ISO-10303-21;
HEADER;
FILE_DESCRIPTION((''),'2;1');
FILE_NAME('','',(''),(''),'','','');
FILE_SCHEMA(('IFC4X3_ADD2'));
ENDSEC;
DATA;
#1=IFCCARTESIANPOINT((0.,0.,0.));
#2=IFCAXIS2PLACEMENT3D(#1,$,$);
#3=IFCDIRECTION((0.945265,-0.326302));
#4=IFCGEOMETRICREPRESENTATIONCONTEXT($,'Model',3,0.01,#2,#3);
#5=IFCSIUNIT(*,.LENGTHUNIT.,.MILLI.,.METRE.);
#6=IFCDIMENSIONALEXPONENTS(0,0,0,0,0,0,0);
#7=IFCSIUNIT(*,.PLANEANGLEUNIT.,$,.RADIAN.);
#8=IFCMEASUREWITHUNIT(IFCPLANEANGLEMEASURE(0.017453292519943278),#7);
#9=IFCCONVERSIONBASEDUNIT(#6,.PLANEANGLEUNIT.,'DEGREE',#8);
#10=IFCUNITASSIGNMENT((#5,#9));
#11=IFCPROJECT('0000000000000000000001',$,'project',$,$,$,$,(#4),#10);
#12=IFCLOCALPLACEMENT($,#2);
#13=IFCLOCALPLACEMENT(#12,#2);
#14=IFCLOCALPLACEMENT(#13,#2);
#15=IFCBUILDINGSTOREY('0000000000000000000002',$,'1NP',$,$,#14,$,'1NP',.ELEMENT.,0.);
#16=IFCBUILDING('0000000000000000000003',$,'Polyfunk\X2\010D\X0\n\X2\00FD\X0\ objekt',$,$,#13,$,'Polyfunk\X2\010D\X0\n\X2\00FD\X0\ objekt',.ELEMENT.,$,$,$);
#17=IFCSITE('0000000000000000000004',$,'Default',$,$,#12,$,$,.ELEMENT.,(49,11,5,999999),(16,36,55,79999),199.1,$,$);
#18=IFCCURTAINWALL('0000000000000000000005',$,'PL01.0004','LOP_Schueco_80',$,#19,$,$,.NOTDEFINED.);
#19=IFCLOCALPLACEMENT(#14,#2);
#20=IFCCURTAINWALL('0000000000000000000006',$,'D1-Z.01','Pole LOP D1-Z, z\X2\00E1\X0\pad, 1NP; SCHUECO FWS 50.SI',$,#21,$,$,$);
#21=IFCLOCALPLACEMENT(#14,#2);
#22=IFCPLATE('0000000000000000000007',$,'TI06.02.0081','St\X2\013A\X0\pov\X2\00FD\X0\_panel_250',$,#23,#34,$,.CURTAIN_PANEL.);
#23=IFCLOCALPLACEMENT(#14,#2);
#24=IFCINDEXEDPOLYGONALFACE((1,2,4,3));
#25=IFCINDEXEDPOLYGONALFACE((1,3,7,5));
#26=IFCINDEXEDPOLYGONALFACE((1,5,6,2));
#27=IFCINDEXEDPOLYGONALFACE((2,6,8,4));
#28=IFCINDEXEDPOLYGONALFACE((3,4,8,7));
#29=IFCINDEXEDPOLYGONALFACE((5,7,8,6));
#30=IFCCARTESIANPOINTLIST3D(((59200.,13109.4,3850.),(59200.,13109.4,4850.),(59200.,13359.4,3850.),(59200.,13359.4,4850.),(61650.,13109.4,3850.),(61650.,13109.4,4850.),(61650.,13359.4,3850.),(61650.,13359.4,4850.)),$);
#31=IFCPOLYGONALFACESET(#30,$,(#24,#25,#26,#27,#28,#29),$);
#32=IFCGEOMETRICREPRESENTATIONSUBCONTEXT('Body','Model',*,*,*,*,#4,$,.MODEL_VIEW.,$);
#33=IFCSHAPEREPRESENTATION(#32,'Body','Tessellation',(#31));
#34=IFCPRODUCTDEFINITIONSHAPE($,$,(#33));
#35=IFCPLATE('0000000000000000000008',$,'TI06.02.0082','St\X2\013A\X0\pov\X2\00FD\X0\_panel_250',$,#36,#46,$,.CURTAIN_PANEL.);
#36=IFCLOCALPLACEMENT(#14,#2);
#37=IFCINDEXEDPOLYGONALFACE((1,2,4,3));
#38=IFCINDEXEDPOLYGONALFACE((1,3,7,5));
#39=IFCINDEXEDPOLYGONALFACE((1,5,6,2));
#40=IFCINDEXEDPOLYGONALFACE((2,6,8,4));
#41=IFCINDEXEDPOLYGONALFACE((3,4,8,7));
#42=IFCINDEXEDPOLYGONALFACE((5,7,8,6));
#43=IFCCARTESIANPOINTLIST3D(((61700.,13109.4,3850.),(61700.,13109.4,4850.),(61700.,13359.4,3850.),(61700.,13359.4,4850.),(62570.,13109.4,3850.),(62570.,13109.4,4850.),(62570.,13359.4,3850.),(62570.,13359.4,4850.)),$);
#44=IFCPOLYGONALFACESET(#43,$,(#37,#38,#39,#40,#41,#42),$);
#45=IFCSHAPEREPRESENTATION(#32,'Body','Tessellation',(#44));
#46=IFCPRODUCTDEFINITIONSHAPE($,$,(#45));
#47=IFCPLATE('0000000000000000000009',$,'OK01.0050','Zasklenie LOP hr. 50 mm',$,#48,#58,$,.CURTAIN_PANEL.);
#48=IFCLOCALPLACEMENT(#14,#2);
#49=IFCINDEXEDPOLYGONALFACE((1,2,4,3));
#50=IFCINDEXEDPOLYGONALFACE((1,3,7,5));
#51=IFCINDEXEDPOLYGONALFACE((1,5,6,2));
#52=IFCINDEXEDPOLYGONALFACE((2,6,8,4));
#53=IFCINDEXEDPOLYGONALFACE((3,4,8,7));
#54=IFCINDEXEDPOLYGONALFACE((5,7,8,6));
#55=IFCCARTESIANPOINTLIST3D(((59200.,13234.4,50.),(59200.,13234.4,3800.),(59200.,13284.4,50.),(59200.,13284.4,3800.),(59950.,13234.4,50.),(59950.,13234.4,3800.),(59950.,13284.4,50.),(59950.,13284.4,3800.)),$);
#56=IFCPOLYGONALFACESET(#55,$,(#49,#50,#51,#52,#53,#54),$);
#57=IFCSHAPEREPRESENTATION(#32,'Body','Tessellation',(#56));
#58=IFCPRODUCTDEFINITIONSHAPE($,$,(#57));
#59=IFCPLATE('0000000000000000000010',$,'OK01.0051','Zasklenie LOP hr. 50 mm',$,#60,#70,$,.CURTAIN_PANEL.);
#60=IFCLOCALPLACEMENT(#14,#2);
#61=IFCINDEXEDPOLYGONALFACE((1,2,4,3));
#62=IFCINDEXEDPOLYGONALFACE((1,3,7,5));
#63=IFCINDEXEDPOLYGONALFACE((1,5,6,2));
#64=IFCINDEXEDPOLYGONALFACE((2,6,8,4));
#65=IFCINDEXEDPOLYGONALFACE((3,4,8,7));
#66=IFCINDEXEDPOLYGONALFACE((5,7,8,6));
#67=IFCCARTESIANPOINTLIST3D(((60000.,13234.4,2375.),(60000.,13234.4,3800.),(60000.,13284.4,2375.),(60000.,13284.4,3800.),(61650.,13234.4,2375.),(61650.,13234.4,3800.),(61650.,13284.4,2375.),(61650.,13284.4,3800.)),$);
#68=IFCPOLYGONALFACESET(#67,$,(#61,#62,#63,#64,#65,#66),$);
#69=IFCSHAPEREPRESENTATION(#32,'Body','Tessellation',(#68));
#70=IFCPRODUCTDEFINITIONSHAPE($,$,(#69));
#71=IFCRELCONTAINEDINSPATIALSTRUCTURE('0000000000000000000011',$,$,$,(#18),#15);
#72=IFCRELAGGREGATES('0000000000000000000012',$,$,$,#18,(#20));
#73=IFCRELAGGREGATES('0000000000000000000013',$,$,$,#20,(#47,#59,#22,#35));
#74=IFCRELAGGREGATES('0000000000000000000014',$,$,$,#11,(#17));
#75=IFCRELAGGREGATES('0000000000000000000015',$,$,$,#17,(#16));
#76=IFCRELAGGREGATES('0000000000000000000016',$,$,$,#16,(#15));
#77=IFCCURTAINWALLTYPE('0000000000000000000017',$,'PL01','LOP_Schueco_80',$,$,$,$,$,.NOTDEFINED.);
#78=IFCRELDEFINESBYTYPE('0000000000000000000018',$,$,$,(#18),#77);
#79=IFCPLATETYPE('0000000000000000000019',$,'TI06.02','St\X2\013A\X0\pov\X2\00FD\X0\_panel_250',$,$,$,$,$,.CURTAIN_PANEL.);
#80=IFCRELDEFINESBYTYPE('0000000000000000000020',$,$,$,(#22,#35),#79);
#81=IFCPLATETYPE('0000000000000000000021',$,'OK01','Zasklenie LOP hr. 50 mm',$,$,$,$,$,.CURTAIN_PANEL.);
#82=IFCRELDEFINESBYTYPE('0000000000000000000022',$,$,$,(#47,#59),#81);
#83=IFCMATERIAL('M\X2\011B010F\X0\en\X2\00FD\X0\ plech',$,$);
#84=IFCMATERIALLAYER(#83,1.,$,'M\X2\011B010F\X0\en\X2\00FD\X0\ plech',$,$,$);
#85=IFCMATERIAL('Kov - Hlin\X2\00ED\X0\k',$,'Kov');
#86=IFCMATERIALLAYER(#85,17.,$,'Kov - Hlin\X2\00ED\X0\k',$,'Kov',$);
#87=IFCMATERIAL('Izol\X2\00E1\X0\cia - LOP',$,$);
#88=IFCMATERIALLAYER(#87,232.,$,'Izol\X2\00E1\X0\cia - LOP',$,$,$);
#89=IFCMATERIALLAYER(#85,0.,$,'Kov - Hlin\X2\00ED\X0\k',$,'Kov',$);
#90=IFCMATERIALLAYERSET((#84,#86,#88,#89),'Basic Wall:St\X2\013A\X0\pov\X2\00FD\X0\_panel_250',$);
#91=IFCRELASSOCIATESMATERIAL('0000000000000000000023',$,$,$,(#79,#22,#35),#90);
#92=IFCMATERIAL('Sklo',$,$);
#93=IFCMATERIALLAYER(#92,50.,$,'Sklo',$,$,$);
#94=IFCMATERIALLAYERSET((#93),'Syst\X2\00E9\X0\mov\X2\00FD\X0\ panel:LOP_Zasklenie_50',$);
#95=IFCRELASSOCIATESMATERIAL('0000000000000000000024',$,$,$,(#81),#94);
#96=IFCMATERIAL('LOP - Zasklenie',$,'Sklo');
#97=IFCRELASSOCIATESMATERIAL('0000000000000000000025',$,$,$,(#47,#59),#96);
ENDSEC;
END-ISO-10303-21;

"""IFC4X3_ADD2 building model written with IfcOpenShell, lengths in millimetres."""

from ifc_helpers import new_model, entity, si_unit, converted_unit, direction, frame, frame_2d, origin, origin_2d_with_axis, place, context, subcontext, project, spatial, rectangle, extrude, source, transform, mapped, material, layer, layer_set, layer_usage, type_object, type_shapes, element, aggregate, save


model = new_model("IFC4X3_ADD2")

# Units and contexts
model_context = context("Model", 3, precision=0.01, world=origin(), true_north=direction((0.945265, -0.326302)))
body_context = subcontext(model_context, "Body", "Model", "MODEL_VIEW")
ifc_project = project(units=[si_unit("LENGTHUNIT", "METRE", prefix="MILLI"), converted_unit("PLANEANGLEUNIT", "DEGREE", entity("IfcPlaneAngleMeasure", 0.017453292519943278), si_unit("PLANEANGLEUNIT", "RADIAN"), dimensions=[0, 0, 0, 0, 0, 0, 0])], contexts=[model_context])

# Site, building, storey
site_placement = place(None, origin())
site = spatial("IfcSite", under=ifc_project, at=site_placement, Name="Default", CompositionType="ELEMENT", RefLatitude=(49, 11, 5, 999999), RefLongitude=(16, 36, 55, 79999), RefElevation=199.1)
building_placement = place(site_placement, origin())
building = spatial("IfcBuilding", under=site, at=building_placement, Name="Polyfunkčný objekt", LongName="Polyfunkčný objekt", CompositionType="ELEMENT")
storey_placement = place(building_placement, origin())
storey = spatial("IfcBuildingStorey", under=building, at=storey_placement, Name="1NP", LongName="1NP", CompositionType="ELEMENT", Elevation=0.0)

# Curtain walls, plates
curtain_wall_type = type_object("IfcCurtainWallType", Name="PL01", Description="LOP_Schueco_80", PredefinedType="NOTDEFINED")
curtain_wall_1_placement = place(storey_placement, origin())
curtain_wall_1 = element("IfcCurtainWall", 1, at=curtain_wall_1_placement, inside=storey, type_object=curtain_wall_type, Name="PL01.0004", Description="LOP_Schueco_80", PredefinedType="NOTDEFINED")
curtain_wall_2 = element("IfcCurtainWall", 2, Name="D1-Z.01", Description="Pole LOP D1-Z, západ, 1NP; SCHUECO FWS 50.SI")
aggregate(curtain_wall_1, [curtain_wall_2])
ifc_material_1 = material(Name="Měďený plech")
ifc_layer_1 = layer(ifc_material_1, 1.0, Name="Měďený plech")
ifc_material_2 = material(Name="Kov - Hliník", Category="Kov")
ifc_layer_2 = layer(ifc_material_2, 17.0, Name="Kov - Hliník", Category="Kov")
ifc_material_3 = material(Name="Izolácia - LOP")
ifc_layer_3 = layer(ifc_material_3, 232.0, Name="Izolácia - LOP")
ifc_layer_4 = layer(ifc_material_2, 0.0, Name="Kov - Hliník", Category="Kov")
ifc_layer_set_1 = layer_set([ifc_layer_1, ifc_layer_2, ifc_layer_3, ifc_layer_4], Name="Basic Wall:Stĺpový_panel_250")
ifc_layer_usage_1 = layer_usage(ifc_layer_set_1, "AXIS2", "NEGATIVE", 125.0)
plate_type_1 = type_object("IfcPlateType", Name="TI06.02", Description="Stĺpový_panel_250", PredefinedType="CURTAIN_PANEL", material=ifc_layer_set_1)
plate_1_placement = place(storey_placement, frame((59200.0, 13234.4, 3850.0)))
plate_1 = element("IfcPlate", 3, at=plate_1_placement, type_object=plate_type_1, material=ifc_layer_usage_1, Name="TI06.02.0081", Description="Stĺpový_panel_250", PredefinedType="CURTAIN_PANEL", context=body_context, shape_type="SweptSolid", body=[
    extrude(rectangle(XDim=250.0, YDim=2450.0, at=frame_2d((0.0, 0.0), x_axis=(1.0, 0.0))), frame((1225.0, 0.0, 0.0), z_axis=(0.0, 0.0, 1.0), x_axis=(0.0, 1.0, 0.0)), (0.0, 0.0, 1.0), 1000.0),
])
ifc_layer_usage_2 = layer_usage(ifc_layer_set_1, "AXIS2", "NEGATIVE", 125.0)
plate_2_placement = place(storey_placement, frame((61700.0, 13234.4, 3850.0)))
plate_2 = element("IfcPlate", 4, at=plate_2_placement, type_object=plate_type_1, material=ifc_layer_usage_2, Name="TI06.02.0082", Description="Stĺpový_panel_250", PredefinedType="CURTAIN_PANEL", context=body_context, shape_type="SweptSolid", body=[
    extrude(rectangle(XDim=250.0, YDim=870.0, at=frame_2d((0.0, 0.0), x_axis=(1.0, 0.0))), frame((435.0, 0.0, 0.0), z_axis=(0.0, 0.0, 1.0), x_axis=(0.0, 1.0, 0.0)), (0.0, 0.0, 1.0), 1000.0),
])

# Plates
ifc_material_4 = material(Name="LOP - Zasklenie", Category="Sklo")
ifc_material_5 = material(Name="Sklo")
ifc_layer_5 = layer(ifc_material_5, 50.0, Name="Sklo")
ifc_layer_set_2 = layer_set([ifc_layer_5], Name="Systémový panel:LOP_Zasklenie_50")
plate_type_2 = type_object("IfcPlateType", Name="OK01", Description="Zasklenie LOP hr. 50 mm", PredefinedType="CURTAIN_PANEL", material=ifc_layer_set_2)
shared_shape_1 = source(origin(), body_context, "Body", "SweptSolid", [
    extrude(rectangle(XDim=3750.0, YDim=750.0, at=frame_2d((-141.7, 0.0), x_axis=(1.0, 0.0))), frame((0.0, 0.0, 2016.7), z_axis=(0.0, 1.0, 0.0), x_axis=(0.0, 0.0, 1.0)), (0.0, 0.0, 1.0), 50.0),
])
plate_3_placement = place(curtain_wall_1_placement, frame((59575.0, 13234.4, 50.0)))
plate_3 = element("IfcPlate", 5, at=plate_3_placement, type_object=plate_type_2, material=ifc_material_4, Name="OK01.0050", Description="Zasklenie LOP hr. 50 mm", PredefinedType="CURTAIN_PANEL", context=body_context, shape_type="MappedRepresentation", body=[
    mapped(shared_shape_1, transform((0.0, 0.0, 0.0), scale=1.0)),
])
shared_shape_2 = source(origin(), body_context, "Body", "SweptSolid", [
    extrude(rectangle(XDim=50.0, YDim=1650.0, at=origin_2d_with_axis()), frame((0.0, 25.0, 0.0), z_axis=(0.0, 0.0, 1.0), x_axis=(0.0, 1.0, 0.0)), (0.0, 0.0, 1.0), 1425.0),
])
type_shapes(plate_type_2, [shared_shape_1, shared_shape_2])
plate_4_placement = place(curtain_wall_1_placement, frame((60825.0, 13234.4, 2375.0)))
plate_4 = element("IfcPlate", 6, at=plate_4_placement, type_object=plate_type_2, material=ifc_material_4, Name="OK01.0051", Description="Zasklenie LOP hr. 50 mm", PredefinedType="CURTAIN_PANEL", context=body_context, shape_type="MappedRepresentation", body=[
    mapped(shared_shape_2, transform((0.0, 0.0, 0.0), scale=1.0)),
])
aggregate(curtain_wall_2, [plate_3, plate_4, plate_1, plate_2])

save(model, "model.ifc")
